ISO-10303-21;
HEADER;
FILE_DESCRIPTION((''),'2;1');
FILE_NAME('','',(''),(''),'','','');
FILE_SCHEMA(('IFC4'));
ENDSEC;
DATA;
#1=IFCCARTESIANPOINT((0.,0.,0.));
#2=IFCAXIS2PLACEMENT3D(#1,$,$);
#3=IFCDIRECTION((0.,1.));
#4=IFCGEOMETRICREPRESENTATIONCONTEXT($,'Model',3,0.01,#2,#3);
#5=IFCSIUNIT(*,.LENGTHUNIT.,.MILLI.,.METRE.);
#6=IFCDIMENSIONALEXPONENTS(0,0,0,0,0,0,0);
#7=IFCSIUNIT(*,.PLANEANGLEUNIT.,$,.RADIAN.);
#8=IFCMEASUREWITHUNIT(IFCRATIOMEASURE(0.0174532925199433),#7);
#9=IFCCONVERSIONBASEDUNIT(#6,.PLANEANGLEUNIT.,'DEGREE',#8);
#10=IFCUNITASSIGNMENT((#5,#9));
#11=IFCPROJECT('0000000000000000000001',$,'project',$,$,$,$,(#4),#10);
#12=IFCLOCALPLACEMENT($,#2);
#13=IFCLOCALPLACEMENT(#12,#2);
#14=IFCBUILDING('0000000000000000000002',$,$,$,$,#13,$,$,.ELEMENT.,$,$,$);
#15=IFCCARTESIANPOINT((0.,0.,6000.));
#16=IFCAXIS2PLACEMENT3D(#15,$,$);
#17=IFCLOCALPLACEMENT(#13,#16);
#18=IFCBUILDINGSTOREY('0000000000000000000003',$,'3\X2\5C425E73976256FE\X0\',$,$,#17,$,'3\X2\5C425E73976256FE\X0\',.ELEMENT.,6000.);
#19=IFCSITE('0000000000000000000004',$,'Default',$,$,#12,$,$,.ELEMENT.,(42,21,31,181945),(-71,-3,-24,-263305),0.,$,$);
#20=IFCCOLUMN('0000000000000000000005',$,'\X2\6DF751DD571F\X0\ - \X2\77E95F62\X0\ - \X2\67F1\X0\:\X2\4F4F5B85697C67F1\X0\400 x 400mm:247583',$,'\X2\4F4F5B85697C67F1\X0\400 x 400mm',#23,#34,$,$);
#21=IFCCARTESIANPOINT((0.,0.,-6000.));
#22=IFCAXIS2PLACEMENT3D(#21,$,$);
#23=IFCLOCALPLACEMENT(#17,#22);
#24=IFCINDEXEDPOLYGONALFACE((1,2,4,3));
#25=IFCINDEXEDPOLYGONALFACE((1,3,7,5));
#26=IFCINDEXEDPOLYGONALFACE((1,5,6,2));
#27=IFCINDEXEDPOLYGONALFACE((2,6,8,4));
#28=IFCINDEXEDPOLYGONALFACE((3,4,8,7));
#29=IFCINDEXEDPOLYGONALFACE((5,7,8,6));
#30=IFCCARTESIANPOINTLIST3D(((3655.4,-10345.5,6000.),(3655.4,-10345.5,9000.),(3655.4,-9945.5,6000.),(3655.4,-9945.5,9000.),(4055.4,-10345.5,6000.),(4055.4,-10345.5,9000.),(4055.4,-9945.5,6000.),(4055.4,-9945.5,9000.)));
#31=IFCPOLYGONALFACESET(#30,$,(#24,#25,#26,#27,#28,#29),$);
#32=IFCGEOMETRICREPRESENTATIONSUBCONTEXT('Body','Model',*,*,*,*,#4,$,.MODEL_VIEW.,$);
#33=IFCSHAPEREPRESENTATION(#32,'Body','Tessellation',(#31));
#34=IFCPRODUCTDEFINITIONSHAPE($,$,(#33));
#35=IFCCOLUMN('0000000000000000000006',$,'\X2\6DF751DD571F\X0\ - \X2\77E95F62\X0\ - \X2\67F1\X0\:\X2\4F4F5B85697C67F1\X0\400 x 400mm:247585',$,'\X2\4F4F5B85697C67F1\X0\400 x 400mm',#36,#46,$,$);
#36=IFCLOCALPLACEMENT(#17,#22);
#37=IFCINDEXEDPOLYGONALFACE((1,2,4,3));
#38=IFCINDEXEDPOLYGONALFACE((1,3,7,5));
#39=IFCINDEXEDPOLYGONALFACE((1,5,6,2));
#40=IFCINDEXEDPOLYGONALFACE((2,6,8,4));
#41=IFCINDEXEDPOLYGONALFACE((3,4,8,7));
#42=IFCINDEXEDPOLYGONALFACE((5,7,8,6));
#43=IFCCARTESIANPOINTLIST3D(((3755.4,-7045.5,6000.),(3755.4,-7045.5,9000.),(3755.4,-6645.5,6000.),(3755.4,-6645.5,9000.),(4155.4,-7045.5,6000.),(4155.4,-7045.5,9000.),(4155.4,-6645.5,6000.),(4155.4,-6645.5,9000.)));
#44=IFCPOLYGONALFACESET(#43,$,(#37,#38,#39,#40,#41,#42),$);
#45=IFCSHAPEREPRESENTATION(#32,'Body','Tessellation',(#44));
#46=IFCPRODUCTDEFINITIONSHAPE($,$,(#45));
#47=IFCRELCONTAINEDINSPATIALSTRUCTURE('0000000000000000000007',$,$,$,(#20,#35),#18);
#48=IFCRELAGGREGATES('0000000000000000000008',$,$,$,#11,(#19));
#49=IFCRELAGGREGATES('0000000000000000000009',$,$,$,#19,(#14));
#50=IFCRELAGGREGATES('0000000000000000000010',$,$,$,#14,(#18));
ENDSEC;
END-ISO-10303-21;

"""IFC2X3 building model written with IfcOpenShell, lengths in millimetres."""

from ifc_helpers import new_model, entity, si_unit, converted_unit, direction, frame, origin, origin_2d_with_axis, place, context, subcontext, project, spatial, rectangle, extrude, source, transform, mapped, element, save


model = new_model("IFC2X3")

# Units and contexts
model_context = context("Model", 3, precision=0.01, world=origin(), true_north=direction((0.0, 1.0)))
body_context = subcontext(model_context, "Body", "Model", "MODEL_VIEW")
ifc_project = project(units=[si_unit("LENGTHUNIT", "METRE", prefix="MILLI"), converted_unit("PLANEANGLEUNIT", "DEGREE", entity("IfcRatioMeasure", 0.0174532925199433), si_unit("PLANEANGLEUNIT", "RADIAN"), dimensions=[0, 0, 0, 0, 0, 0, 0])], contexts=[model_context])

# Site, building, storey
site_placement = place(None, origin())
site = spatial("IfcSite", under=ifc_project, at=site_placement, Name="Default", CompositionType="ELEMENT", RefLatitude=(42, 21, 31, 181945), RefLongitude=(-71, -3, -24, -263305), RefElevation=0.0)
building_placement = place(site_placement, origin())
building = spatial("IfcBuilding", under=site, at=building_placement, CompositionType="ELEMENT")
storey_placement = place(building_placement, frame((0.0, 0.0, 6000.0)))
storey = spatial("IfcBuildingStorey", under=building, at=storey_placement, Name="3层平面图", LongName="3层平面图", CompositionType="ELEMENT", Elevation=6000.0)

# Columns
shared_shape_1 = source(origin(), body_context, "Body", "SweptSolid", [
    extrude(rectangle(XDim=400.0, YDim=400.0, at=origin_2d_with_axis()), frame((3855.4, -10145.5, 6000.0), z_axis=(0.0, 0.0, 1.0), x_axis=(0.0, -1.0, 0.0)), (0.0, 0.0, 1.0), 3000.0),
])
column_1_placement = place(storey_placement, frame((0.0, 0.0, -6000.0)))
element("IfcColumn", 1, at=column_1_placement, inside=storey, Name="混凝土 - 矩形 - 柱:住宅楼柱400 x 400mm:247583", ObjectType="住宅楼柱400 x 400mm", context=body_context, shape_type="MappedRepresentation", body=[
    mapped(shared_shape_1, transform((0.0, 0.0, 0.0), scale=1.0)),
])
shared_shape_2 = source(origin(), body_context, "Body", "SweptSolid", [
    extrude(rectangle(XDim=400.0, YDim=400.0, at=origin_2d_with_axis()), frame((3955.4, -6845.5, 6000.0), z_axis=(0.0, 0.0, 1.0), x_axis=(0.0, -1.0, 0.0)), (0.0, 0.0, 1.0), 3000.0),
])
column_2_placement = place(storey_placement, frame((0.0, 0.0, -6000.0)))
element("IfcColumn", 2, at=column_2_placement, inside=storey, Name="混凝土 - 矩形 - 柱:住宅楼柱400 x 400mm:247585", ObjectType="住宅楼柱400 x 400mm", context=body_context, shape_type="MappedRepresentation", body=[
    mapped(shared_shape_2, transform((0.0, 0.0, 0.0), scale=1.0)),
])

save(model, "model.ifc")
